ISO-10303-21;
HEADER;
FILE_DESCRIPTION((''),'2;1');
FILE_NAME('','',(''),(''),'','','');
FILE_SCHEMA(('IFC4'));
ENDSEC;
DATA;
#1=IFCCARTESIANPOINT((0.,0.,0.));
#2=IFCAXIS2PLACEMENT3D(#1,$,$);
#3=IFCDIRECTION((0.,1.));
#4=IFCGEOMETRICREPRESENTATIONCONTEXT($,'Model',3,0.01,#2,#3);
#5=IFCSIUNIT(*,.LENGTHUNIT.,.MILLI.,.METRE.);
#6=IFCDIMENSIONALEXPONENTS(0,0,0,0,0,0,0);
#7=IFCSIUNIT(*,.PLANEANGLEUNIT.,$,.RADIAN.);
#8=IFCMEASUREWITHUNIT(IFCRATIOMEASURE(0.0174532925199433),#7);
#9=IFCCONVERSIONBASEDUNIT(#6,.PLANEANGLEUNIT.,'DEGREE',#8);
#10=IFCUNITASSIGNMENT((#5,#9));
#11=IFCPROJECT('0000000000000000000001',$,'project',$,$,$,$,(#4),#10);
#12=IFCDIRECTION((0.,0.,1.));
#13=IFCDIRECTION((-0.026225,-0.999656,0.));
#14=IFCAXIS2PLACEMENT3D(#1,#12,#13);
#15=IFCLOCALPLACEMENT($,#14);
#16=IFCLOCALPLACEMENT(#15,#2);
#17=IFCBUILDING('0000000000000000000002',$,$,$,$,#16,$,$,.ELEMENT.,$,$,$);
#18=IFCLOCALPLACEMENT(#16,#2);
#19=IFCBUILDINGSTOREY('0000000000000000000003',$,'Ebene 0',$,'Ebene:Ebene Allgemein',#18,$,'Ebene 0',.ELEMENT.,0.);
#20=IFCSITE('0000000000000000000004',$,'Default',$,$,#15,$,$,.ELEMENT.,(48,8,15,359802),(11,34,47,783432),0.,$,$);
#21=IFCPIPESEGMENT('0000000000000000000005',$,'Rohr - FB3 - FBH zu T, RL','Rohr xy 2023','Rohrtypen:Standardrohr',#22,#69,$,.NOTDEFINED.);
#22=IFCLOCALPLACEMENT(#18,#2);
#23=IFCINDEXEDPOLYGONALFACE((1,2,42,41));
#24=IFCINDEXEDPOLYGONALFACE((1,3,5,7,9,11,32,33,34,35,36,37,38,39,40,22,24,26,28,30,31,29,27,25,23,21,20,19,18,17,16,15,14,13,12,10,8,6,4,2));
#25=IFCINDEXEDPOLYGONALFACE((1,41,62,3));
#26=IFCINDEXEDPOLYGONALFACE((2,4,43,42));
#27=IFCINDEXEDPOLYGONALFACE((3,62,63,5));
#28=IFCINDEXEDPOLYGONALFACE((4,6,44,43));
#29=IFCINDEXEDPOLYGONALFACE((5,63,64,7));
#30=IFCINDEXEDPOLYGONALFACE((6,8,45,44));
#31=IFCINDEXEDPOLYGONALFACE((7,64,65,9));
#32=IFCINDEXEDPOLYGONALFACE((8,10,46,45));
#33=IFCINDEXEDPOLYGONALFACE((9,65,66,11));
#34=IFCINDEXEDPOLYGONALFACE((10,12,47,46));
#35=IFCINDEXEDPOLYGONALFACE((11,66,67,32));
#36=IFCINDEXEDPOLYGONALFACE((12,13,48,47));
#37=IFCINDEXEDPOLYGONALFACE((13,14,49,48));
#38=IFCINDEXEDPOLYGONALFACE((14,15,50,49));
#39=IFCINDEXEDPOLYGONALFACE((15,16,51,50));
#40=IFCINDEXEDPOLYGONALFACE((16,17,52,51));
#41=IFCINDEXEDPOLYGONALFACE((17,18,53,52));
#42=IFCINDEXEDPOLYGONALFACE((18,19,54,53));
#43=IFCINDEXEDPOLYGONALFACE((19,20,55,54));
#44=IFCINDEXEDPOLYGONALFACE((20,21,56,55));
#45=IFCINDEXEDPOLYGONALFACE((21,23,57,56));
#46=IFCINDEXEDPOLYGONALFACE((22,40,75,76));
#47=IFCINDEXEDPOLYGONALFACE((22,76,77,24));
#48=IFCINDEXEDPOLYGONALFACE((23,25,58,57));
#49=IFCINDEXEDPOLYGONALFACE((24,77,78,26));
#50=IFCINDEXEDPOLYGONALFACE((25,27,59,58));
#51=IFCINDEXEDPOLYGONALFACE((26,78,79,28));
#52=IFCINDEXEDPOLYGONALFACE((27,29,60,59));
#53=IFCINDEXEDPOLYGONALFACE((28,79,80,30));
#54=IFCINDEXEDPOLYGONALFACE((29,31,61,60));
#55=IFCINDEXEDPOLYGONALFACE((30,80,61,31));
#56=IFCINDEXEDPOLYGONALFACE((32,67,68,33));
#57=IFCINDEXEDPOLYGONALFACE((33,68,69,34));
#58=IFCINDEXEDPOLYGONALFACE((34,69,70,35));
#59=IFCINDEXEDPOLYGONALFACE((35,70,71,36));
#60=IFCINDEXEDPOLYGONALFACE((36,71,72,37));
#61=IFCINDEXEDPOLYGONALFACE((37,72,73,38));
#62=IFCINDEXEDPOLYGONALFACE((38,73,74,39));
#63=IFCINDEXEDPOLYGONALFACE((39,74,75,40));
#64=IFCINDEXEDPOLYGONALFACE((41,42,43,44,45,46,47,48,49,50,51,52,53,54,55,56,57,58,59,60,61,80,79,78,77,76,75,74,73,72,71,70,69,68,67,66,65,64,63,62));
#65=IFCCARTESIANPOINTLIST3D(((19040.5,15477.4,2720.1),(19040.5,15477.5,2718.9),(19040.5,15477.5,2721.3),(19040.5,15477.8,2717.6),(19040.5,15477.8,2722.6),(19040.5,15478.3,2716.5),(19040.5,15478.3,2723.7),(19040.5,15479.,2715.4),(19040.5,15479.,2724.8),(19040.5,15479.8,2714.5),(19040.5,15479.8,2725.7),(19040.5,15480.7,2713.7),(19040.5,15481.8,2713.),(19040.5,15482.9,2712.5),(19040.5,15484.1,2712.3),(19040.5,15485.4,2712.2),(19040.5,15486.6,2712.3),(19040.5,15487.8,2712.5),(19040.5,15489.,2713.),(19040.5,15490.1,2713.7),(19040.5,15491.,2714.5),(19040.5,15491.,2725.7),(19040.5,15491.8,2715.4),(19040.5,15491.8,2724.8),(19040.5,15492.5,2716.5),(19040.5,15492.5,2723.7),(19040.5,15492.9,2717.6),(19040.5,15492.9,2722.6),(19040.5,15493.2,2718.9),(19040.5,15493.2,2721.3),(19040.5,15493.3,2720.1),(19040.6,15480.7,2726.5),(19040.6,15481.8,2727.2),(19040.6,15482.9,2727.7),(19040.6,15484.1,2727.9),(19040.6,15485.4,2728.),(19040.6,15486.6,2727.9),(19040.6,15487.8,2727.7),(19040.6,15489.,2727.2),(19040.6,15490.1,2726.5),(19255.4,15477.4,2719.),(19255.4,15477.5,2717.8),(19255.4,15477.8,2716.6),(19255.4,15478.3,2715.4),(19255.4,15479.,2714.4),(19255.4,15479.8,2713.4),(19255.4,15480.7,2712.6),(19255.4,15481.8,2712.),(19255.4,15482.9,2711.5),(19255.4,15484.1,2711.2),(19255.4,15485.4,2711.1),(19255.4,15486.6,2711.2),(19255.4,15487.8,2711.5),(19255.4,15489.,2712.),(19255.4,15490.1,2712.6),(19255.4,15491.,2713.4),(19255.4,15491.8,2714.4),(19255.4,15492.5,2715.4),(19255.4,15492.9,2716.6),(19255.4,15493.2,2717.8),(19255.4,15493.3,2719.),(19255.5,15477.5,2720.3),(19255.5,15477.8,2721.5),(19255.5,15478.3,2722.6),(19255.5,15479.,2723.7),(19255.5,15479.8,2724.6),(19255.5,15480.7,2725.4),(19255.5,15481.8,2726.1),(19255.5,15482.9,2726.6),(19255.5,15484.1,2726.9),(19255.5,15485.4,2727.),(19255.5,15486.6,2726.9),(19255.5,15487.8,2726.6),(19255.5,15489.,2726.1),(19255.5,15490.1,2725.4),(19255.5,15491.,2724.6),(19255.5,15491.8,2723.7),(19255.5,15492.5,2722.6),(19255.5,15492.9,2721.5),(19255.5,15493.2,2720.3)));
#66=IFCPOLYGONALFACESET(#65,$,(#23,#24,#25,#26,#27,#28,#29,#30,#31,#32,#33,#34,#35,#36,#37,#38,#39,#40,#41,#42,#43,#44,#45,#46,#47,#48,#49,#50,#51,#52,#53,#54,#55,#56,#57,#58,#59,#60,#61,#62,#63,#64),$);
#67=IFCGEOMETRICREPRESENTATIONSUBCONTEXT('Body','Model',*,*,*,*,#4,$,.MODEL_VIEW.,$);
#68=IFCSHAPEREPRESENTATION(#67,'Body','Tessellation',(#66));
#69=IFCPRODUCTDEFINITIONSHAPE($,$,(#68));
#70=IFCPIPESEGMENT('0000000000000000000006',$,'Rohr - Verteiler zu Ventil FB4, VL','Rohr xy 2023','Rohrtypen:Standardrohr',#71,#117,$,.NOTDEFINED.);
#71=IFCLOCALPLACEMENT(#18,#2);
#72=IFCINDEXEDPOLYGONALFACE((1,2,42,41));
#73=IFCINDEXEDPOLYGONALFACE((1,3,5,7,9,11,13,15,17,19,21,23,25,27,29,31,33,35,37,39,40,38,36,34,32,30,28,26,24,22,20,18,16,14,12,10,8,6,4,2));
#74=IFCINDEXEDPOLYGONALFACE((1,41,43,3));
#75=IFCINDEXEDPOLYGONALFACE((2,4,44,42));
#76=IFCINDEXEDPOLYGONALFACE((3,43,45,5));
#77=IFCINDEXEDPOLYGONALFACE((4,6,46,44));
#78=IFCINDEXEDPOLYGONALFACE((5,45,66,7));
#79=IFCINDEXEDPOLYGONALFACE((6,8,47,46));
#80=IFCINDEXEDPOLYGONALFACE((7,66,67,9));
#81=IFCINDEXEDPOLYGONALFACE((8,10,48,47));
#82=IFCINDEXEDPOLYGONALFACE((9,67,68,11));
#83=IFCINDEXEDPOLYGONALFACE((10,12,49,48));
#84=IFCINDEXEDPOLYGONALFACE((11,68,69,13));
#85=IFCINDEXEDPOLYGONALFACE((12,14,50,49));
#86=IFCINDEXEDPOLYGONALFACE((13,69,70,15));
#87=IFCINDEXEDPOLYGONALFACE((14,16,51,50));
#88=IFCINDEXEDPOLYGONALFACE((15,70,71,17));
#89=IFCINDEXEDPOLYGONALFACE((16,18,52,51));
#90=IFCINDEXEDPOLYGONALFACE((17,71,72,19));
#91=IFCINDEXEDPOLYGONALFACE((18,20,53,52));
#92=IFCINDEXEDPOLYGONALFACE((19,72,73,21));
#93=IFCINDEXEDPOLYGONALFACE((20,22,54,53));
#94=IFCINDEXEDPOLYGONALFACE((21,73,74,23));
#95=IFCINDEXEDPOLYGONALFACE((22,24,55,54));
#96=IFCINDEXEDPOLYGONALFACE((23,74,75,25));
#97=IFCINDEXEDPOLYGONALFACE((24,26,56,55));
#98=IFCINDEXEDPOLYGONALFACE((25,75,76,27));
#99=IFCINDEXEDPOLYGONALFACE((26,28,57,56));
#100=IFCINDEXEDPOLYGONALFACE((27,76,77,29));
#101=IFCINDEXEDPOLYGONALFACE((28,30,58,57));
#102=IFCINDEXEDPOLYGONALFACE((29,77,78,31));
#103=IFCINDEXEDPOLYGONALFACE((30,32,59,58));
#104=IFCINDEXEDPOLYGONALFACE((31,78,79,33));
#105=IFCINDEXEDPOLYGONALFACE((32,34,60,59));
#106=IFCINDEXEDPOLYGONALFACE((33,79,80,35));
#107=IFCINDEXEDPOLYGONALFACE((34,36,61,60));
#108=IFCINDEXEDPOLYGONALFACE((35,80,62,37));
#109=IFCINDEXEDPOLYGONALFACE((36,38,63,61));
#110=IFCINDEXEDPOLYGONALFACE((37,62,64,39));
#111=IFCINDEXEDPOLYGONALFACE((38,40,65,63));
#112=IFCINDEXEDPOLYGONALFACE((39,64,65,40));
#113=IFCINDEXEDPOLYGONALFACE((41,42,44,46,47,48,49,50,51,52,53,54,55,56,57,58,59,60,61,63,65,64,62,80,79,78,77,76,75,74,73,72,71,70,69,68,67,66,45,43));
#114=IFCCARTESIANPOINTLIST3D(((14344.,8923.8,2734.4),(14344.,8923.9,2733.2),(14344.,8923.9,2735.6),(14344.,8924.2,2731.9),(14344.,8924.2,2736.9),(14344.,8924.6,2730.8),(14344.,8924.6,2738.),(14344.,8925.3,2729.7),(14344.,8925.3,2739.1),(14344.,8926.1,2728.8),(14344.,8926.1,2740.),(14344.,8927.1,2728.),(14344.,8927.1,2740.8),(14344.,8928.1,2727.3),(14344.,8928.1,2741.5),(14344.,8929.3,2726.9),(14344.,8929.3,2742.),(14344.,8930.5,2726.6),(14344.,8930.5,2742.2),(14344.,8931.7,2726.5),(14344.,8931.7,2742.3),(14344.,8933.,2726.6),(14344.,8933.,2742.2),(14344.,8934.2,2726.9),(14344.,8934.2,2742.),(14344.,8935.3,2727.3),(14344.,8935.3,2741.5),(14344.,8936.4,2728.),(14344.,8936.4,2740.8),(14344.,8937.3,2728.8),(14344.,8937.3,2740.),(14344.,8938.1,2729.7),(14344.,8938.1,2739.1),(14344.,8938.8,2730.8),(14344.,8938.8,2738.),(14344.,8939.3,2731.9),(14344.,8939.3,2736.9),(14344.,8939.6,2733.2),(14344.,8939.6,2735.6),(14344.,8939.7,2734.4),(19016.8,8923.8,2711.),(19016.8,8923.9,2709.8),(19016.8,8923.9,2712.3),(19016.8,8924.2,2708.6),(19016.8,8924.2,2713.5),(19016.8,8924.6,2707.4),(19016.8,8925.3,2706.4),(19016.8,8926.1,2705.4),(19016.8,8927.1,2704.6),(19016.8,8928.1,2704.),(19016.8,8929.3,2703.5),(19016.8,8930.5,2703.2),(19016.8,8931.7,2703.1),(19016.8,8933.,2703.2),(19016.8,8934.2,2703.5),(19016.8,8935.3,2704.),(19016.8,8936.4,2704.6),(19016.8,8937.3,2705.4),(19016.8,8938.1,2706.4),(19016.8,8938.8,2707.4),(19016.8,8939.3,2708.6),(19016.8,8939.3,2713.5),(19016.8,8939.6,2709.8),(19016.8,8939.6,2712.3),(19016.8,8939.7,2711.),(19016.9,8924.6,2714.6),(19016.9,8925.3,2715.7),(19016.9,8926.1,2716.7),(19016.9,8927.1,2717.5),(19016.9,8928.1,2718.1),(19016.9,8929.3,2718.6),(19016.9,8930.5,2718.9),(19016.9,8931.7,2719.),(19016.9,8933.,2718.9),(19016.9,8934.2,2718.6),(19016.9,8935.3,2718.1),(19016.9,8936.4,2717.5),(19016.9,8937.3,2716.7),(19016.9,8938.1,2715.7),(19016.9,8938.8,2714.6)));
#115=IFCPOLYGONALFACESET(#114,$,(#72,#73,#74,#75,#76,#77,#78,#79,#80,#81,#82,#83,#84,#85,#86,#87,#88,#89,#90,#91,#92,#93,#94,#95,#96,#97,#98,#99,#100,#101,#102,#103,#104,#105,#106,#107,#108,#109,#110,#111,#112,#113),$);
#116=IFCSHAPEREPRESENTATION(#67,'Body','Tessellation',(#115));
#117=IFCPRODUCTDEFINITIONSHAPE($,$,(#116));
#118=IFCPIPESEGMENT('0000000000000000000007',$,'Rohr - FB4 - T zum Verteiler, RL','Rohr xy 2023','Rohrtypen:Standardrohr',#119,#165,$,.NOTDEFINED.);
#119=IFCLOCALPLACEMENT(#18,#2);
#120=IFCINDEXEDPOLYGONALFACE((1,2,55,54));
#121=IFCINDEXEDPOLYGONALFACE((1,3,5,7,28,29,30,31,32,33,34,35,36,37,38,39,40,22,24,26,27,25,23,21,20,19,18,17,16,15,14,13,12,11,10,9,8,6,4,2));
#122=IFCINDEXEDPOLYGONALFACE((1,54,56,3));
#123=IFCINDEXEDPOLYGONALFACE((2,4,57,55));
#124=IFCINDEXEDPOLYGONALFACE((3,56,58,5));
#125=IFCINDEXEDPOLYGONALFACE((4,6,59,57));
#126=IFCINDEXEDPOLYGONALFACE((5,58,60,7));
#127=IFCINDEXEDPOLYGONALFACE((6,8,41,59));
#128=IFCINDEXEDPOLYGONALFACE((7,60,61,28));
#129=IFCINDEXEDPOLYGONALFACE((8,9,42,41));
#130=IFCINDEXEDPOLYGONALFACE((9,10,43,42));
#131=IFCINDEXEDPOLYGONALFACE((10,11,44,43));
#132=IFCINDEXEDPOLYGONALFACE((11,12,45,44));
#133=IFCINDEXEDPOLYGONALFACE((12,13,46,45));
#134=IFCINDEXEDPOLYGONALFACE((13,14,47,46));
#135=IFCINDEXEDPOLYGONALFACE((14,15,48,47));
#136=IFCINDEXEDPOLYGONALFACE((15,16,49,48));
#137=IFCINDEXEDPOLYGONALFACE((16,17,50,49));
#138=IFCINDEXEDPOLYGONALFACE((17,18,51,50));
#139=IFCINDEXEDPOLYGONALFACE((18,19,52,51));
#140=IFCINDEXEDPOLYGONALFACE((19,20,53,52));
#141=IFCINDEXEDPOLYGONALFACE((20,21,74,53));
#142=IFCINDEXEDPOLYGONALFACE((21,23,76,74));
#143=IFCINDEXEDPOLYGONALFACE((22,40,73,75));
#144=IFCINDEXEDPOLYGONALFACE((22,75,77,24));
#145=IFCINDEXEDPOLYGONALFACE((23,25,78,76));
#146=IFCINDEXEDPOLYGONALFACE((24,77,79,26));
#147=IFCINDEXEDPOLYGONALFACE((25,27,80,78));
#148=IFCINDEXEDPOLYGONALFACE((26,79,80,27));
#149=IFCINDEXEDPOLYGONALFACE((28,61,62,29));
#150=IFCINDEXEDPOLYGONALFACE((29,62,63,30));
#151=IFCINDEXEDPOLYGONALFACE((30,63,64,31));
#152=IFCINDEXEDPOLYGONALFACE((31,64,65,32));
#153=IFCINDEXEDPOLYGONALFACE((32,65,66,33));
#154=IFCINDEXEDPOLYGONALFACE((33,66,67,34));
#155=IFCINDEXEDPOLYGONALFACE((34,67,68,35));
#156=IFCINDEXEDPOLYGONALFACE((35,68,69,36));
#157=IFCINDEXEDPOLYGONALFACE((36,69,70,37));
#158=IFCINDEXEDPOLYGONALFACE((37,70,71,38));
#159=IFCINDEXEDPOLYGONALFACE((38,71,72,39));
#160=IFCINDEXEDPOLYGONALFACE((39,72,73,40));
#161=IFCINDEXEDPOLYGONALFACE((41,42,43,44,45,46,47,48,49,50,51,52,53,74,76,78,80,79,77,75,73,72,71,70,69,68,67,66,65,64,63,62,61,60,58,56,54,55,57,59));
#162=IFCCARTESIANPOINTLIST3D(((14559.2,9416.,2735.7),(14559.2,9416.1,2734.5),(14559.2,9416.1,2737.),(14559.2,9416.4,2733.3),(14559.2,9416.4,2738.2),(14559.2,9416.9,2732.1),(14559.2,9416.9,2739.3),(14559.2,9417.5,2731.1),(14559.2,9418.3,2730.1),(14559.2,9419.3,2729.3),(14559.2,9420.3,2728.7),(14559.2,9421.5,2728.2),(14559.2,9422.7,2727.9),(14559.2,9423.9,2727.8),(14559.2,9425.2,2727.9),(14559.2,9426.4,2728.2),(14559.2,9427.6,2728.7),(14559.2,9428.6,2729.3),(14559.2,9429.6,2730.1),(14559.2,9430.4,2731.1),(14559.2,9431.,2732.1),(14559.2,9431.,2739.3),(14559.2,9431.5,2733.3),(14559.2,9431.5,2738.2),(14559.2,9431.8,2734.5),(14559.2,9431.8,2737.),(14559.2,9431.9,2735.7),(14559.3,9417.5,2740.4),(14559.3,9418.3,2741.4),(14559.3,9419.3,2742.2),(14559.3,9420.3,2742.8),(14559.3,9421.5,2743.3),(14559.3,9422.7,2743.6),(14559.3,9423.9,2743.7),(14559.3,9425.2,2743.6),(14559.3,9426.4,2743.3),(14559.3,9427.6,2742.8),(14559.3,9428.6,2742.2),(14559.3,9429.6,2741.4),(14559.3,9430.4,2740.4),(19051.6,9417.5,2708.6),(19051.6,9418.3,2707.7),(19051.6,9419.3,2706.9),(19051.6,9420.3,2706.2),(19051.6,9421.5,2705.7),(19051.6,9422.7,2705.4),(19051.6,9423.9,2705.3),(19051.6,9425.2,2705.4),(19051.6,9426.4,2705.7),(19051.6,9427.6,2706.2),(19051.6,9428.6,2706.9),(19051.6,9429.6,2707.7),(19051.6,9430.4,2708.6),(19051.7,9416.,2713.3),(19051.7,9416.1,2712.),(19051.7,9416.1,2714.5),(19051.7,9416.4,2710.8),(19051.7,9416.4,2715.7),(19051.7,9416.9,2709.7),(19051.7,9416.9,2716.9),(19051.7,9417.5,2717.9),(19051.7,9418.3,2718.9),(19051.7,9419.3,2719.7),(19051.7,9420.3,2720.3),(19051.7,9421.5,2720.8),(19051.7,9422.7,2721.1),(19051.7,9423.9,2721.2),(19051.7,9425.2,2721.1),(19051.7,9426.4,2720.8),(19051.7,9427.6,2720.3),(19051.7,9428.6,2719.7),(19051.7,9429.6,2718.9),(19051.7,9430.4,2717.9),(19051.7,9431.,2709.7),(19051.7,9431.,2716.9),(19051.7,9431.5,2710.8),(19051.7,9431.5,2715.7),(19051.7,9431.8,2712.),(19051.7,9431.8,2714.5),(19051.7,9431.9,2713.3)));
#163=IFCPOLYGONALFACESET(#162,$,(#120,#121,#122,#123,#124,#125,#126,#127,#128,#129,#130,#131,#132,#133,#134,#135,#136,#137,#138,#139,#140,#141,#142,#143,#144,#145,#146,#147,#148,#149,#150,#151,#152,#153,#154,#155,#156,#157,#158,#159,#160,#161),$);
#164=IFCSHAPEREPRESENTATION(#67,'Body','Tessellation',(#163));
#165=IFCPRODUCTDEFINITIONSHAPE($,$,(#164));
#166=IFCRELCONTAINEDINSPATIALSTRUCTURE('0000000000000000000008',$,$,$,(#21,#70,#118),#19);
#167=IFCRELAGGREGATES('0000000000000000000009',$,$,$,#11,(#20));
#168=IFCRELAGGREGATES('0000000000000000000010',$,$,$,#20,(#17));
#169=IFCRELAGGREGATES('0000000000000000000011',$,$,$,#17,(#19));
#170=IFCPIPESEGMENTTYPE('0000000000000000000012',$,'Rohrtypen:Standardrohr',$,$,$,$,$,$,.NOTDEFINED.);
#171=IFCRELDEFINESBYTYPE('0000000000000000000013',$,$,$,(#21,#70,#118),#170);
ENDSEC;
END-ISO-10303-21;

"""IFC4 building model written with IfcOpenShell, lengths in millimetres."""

from ifc_helpers import new_model, entity, si_unit, converted_unit, direction, frame, origin, place, context, subcontext, project, spatial, indexed_curve, outline, extrude, type_object, element, save


model = new_model("IFC4")

# Units and contexts
model_context = context("Model", 3, precision=0.01, world=origin(), true_north=direction((0.0, 1.0)))
body_context = subcontext(model_context, "Body", "Model", "MODEL_VIEW")
ifc_project = project(units=[si_unit("LENGTHUNIT", "METRE", prefix="MILLI"), converted_unit("PLANEANGLEUNIT", "DEGREE", entity("IfcRatioMeasure", 0.0174532925199433), si_unit("PLANEANGLEUNIT", "RADIAN"), dimensions=[0, 0, 0, 0, 0, 0, 0])], contexts=[model_context])

# Site, building, storey
site_placement = place(None, frame((0.0, 0.0, 0.0), z_axis=(0.0, 0.0, 1.0), x_axis=(-0.026225, -0.999656, 0.0)))
site = spatial("IfcSite", under=ifc_project, at=site_placement, Name="Default", CompositionType="ELEMENT", RefLatitude=(48, 8, 15, 359802), RefLongitude=(11, 34, 47, 783432), RefElevation=0.0)
building_placement = place(site_placement, origin())
building = spatial("IfcBuilding", under=site, at=building_placement, CompositionType="ELEMENT")
storey_placement = place(building_placement, origin())
storey = spatial("IfcBuildingStorey", under=building, at=storey_placement, Name="Ebene 0", ObjectType="Ebene:Ebene Allgemein", LongName="Ebene 0", CompositionType="ELEMENT", Elevation=0.0)

# Pipe segments
pipe_segment_type = type_object("IfcPipeSegmentType", Name="Rohrtypen:Standardrohr", PredefinedType="NOTDEFINED")
pipe_segment_1_placement = place(storey_placement, origin())
element("IfcPipeSegment", 1, at=pipe_segment_1_placement, inside=storey, type_object=pipe_segment_type, Name="Rohr - FB3 - FBH zu T, RL", Description="Rohr xy 2023", ObjectType="Rohrtypen:Standardrohr", PredefinedType="NOTDEFINED", context=body_context, shape_type="SweptSolid", body=[
    extrude(outline(indexed_curve([(7.9, 0.0), (7.8, 1.2), (7.6, 2.5), (7.1, 3.6), (6.4, 4.7), (5.6, 5.6), (4.7, 6.4), (3.6, 7.1), (2.5, 7.6), (1.2, 7.8), (0.0, 7.9), (-1.2, 7.8), (-2.5, 7.6), (-3.6, 7.1), (-4.7, 6.4), (-5.6, 5.6), (-6.4, 4.7), (-7.1, 3.6), (-7.6, 2.5), (-7.8, 1.2), (-7.9, 0.0), (-7.8, -1.2), (-7.6, -2.5), (-7.1, -3.6), (-6.4, -4.7), (-5.6, -5.6), (-4.7, -6.4), (-3.6, -7.1), (-2.5, -7.6), (-1.2, -7.8), (0.0, -7.9), (1.2, -7.8), (2.5, -7.6), (3.6, -7.1), (4.7, -6.4), (5.6, -5.6), (6.4, -4.7), (7.1, -3.6), (7.6, -2.5), (7.8, -1.2), (7.9, 0.0)], self_intersect=False)), frame((19255.4, 15485.4, 2719.0), z_axis=(-0.999988, 0.0, 0.005), x_axis=(0.0, 1.0, 0.0)), (0.0, 0.0, 1.0), 214.9),
])
pipe_segment_2_placement = place(storey_placement, origin())
element("IfcPipeSegment", 2, at=pipe_segment_2_placement, inside=storey, type_object=pipe_segment_type, Name="Rohr - Verteiler zu Ventil FB4, VL", Description="Rohr xy 2023", ObjectType="Rohrtypen:Standardrohr", PredefinedType="NOTDEFINED", context=body_context, shape_type="SweptSolid", body=[
    extrude(outline(indexed_curve([(7.9, 0.0), (7.8, 1.2), (7.6, 2.5), (7.1, 3.6), (6.4, 4.7), (5.6, 5.6), (4.7, 6.4), (3.6, 7.1), (2.5, 7.6), (1.2, 7.8), (0.0, 7.9), (-1.2, 7.8), (-2.5, 7.6), (-3.6, 7.1), (-4.7, 6.4), (-5.6, 5.6), (-6.4, 4.7), (-7.1, 3.6), (-7.6, 2.5), (-7.8, 1.2), (-7.9, 0.0), (-7.8, -1.2), (-7.6, -2.5), (-7.1, -3.6), (-6.4, -4.7), (-5.6, -5.6), (-4.7, -6.4), (-3.6, -7.1), (-2.5, -7.6), (-1.2, -7.8), (0.0, -7.9), (1.2, -7.8), (2.5, -7.6), (3.6, -7.1), (4.7, -6.4), (5.6, -5.6), (6.4, -4.7), (7.1, -3.6), (7.6, -2.5), (7.8, -1.2), (7.9, 0.0)], self_intersect=False)), frame((19016.8, 8931.7, 2711.0), z_axis=(-0.999988, 0.0, 0.005), x_axis=(0.0, 1.0, 0.0)), (0.0, 0.0, 1.0), 4672.9),
])
pipe_segment_3_placement = place(storey_placement, origin())
element("IfcPipeSegment", 3, at=pipe_segment_3_placement, inside=storey, type_object=pipe_segment_type, Name="Rohr - FB4 - T zum Verteiler, RL", Description="Rohr xy 2023", ObjectType="Rohrtypen:Standardrohr", PredefinedType="NOTDEFINED", context=body_context, shape_type="SweptSolid", body=[
    extrude(outline(indexed_curve([(7.9, 0.0), (7.8, 1.2), (7.6, 2.5), (7.1, 3.6), (6.4, 4.7), (5.6, 5.6), (4.7, 6.4), (3.6, 7.1), (2.5, 7.6), (1.2, 7.8), (0.0, 7.9), (-1.2, 7.8), (-2.5, 7.6), (-3.6, 7.1), (-4.7, 6.4), (-5.6, 5.6), (-6.4, 4.7), (-7.1, 3.6), (-7.6, 2.5), (-7.8, 1.2), (-7.9, 0.0), (-7.8, -1.2), (-7.6, -2.5), (-7.1, -3.6), (-6.4, -4.7), (-5.6, -5.6), (-4.7, -6.4), (-3.6, -7.1), (-2.5, -7.6), (-1.2, -7.8), (0.0, -7.9), (1.2, -7.8), (2.5, -7.6), (3.6, -7.1), (4.7, -6.4), (5.6, -5.6), (6.4, -4.7), (7.1, -3.6), (7.6, -2.5), (7.8, -1.2), (7.9, 0.0)], self_intersect=False)), frame((14559.2, 9423.9, 2735.7), z_axis=(0.999988, 0.0, -0.005), x_axis=(0.0, 1.0, 0.0)), (0.0, 0.0, 1.0), 4492.5),
])

save(model, "model.ifc")
